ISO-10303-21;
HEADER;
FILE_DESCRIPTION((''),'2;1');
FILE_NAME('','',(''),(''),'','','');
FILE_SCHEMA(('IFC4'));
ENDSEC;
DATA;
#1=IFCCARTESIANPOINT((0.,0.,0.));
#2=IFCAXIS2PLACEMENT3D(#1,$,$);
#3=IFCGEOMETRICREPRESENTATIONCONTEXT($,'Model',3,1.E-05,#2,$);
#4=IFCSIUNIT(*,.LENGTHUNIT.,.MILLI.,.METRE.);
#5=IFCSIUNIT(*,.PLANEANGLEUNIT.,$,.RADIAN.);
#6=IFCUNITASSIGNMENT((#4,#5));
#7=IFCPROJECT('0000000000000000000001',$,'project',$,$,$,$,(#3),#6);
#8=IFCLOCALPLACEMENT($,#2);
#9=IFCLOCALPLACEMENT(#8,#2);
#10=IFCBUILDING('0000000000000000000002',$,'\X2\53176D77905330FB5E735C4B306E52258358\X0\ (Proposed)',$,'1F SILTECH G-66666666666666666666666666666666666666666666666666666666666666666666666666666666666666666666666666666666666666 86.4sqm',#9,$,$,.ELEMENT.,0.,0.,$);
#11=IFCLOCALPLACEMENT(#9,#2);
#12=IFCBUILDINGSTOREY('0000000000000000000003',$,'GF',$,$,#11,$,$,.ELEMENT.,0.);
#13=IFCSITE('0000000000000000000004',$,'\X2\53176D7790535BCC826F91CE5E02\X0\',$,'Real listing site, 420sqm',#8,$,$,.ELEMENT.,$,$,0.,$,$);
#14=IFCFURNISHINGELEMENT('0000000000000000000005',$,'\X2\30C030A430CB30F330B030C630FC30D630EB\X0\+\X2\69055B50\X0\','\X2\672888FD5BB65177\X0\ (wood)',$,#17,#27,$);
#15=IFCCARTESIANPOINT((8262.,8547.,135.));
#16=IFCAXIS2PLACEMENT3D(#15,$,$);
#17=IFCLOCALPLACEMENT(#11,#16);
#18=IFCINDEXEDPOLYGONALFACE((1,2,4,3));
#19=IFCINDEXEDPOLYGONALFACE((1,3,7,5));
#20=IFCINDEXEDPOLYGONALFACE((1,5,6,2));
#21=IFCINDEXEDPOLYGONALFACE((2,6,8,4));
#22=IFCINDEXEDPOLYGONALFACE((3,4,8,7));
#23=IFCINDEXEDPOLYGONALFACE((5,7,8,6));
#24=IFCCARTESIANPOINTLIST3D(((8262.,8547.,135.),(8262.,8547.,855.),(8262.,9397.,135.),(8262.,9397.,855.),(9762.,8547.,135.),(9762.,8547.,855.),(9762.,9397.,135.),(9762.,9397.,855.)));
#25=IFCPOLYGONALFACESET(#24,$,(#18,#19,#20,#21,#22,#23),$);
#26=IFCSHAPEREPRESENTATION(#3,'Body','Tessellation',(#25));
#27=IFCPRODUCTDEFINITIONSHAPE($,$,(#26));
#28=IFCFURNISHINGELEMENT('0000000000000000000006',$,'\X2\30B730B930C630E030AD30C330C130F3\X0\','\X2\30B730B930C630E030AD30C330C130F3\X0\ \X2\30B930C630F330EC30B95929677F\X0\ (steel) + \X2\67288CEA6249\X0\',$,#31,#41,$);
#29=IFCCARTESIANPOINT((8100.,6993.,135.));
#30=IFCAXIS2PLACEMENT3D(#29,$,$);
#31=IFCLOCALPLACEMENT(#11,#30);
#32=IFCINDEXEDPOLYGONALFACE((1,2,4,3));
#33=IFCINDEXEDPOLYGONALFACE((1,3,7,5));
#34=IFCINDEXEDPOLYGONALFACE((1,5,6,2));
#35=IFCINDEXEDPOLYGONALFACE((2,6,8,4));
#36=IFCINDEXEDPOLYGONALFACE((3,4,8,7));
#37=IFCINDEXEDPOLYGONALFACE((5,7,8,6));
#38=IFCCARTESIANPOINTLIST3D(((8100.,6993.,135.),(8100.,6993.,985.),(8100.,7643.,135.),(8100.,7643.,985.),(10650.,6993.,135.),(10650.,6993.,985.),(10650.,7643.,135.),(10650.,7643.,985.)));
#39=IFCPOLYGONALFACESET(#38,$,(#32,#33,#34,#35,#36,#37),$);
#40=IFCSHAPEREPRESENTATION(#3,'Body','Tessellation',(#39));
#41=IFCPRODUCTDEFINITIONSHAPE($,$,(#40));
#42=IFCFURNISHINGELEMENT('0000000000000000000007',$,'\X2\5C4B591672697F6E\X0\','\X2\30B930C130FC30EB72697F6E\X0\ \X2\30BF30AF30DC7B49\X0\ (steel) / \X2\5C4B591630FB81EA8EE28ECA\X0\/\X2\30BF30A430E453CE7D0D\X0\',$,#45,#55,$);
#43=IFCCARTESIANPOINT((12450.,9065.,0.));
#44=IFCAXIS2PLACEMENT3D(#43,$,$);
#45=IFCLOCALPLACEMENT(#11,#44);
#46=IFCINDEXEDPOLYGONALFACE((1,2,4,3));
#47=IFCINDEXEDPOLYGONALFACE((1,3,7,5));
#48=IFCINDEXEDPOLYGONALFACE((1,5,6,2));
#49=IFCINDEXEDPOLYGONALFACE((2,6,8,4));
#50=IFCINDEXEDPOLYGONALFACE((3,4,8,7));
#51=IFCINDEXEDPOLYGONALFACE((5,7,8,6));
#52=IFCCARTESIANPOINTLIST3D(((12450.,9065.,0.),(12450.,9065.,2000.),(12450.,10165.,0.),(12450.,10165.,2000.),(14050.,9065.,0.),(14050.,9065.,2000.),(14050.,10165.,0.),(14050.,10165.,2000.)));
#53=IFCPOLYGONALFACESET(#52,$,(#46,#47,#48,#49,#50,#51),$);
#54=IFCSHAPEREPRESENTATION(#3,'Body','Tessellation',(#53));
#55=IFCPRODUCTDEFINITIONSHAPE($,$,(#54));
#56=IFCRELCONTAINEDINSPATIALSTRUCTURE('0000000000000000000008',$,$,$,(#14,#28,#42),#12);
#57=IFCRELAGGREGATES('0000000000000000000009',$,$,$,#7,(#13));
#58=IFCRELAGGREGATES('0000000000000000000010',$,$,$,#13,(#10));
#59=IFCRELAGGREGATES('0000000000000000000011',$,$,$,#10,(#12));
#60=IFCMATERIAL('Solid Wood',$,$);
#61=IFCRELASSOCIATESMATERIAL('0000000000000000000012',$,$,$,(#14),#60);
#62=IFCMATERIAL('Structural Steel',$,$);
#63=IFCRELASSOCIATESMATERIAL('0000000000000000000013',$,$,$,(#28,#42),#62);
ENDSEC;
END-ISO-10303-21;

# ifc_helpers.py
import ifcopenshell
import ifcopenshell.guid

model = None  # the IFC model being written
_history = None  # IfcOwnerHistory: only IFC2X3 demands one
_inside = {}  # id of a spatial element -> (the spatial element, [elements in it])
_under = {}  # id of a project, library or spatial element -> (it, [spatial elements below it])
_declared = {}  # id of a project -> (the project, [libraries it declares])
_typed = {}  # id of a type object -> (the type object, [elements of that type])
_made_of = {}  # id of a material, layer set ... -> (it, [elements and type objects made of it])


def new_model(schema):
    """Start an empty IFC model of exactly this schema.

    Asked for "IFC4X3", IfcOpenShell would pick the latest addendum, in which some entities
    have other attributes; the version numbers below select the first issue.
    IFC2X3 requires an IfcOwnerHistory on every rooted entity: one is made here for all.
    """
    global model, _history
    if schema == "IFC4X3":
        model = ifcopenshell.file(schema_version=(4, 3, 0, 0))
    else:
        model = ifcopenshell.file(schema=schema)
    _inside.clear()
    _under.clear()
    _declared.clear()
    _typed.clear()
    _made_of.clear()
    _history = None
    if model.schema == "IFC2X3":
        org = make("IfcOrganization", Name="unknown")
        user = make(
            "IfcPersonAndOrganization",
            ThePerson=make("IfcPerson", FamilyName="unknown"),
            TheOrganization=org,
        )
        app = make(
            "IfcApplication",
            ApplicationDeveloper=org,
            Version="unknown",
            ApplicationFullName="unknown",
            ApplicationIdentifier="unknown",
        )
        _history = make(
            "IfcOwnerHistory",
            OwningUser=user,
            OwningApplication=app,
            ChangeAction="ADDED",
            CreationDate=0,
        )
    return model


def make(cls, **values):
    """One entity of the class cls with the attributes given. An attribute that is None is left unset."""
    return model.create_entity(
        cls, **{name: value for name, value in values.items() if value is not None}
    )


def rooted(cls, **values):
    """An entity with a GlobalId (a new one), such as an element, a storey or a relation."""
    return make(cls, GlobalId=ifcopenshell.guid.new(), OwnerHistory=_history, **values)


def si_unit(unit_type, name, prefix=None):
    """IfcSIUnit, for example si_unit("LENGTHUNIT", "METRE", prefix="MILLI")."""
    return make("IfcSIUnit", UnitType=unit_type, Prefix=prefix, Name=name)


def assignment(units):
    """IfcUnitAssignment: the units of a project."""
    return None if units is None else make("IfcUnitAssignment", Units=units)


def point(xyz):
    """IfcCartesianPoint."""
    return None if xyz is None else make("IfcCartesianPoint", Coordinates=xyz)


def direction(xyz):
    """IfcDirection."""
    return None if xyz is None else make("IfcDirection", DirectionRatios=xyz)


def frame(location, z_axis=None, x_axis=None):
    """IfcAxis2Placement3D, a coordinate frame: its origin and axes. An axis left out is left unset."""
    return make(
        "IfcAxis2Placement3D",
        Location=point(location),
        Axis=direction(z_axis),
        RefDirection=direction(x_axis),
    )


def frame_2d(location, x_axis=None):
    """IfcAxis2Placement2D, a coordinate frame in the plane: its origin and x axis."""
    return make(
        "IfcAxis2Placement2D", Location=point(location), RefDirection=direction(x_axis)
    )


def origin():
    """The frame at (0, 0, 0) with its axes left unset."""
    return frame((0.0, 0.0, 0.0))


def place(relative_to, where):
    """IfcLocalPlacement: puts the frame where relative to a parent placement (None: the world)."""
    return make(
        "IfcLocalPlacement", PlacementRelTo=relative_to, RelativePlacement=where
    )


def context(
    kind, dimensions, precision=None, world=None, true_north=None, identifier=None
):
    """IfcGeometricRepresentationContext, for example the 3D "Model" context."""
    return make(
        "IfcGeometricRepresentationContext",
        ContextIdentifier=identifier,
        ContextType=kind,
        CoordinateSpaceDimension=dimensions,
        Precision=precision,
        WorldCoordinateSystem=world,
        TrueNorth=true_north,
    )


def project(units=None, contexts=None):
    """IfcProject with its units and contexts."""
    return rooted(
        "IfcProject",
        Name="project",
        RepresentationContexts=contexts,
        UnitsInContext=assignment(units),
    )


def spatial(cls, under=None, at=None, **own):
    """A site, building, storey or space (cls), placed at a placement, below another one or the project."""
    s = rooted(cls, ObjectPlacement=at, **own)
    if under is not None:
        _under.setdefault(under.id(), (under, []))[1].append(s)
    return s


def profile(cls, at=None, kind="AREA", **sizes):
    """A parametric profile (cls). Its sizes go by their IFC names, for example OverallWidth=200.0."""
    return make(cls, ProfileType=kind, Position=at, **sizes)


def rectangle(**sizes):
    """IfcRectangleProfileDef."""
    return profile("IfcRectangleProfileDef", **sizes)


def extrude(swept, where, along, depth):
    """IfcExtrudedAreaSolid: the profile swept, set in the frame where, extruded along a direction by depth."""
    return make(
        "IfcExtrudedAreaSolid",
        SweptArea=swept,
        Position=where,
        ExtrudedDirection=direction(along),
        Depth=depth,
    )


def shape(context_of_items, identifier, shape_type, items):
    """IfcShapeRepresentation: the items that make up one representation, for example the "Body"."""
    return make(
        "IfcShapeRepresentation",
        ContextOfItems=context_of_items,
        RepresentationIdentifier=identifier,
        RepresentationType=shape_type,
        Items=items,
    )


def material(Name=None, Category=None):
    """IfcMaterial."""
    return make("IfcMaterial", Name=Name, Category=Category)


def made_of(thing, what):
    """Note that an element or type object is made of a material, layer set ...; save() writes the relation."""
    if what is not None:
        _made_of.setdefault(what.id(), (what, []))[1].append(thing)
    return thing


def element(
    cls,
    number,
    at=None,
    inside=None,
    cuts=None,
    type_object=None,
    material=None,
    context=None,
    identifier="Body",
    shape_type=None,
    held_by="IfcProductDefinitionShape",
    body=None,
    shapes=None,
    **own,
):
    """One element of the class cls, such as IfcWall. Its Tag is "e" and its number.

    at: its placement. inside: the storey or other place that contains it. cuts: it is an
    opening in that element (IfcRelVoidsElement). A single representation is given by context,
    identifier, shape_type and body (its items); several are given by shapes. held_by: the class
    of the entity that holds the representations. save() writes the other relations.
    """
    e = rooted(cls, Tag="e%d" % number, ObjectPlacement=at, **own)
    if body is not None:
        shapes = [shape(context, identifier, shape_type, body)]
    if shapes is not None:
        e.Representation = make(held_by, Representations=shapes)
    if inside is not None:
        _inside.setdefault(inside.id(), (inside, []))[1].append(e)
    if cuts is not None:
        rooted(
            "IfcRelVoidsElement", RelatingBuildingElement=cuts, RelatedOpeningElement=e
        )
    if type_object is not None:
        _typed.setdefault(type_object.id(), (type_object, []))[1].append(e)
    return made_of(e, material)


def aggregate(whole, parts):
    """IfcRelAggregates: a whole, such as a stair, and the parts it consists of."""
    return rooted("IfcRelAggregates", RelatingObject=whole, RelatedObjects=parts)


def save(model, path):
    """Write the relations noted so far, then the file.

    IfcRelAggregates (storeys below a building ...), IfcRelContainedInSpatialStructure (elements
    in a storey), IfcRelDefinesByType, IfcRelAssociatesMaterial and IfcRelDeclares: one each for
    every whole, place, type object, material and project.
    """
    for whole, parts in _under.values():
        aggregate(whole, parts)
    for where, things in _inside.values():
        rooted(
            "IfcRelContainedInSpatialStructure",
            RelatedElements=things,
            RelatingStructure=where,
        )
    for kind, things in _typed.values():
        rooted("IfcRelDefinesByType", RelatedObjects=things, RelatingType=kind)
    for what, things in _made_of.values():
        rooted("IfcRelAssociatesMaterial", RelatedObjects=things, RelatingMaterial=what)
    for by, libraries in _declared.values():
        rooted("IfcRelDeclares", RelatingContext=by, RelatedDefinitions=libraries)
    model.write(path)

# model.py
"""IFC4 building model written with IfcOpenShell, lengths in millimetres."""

from ifc_helpers import new_model, si_unit, frame, frame_2d, origin, place, context, project, spatial, rectangle, extrude, material, element, save


model = new_model("IFC4")

# Units and contexts
model_context = context("Model", 3, precision=1e-05, world=origin())
ifc_project = project(units=[si_unit("LENGTHUNIT", "METRE", prefix="MILLI"), si_unit("PLANEANGLEUNIT", "RADIAN")], contexts=[model_context])

# Site, building, storey
site_placement = place(None, origin())
site = spatial("IfcSite", under=ifc_project, at=site_placement, Name="北海道富良野市", ObjectType="Real listing site, 420sqm", CompositionType="ELEMENT", RefElevation=0.0)
building_placement = place(site_placement, origin())
building = spatial("IfcBuilding", under=site, at=building_placement, Name="北海道・平屋の別荘 (Proposed)", ObjectType="1F SILTECH G-66666666666666666666666666666666666666666666666666666666666666666666666666666666666666666666666666666666666666 86.4sqm", CompositionType="ELEMENT", ElevationOfRefHeight=0.0, ElevationOfTerrain=0.0)
storey_placement = place(building_placement, origin())
storey = spatial("IfcBuildingStorey", under=building, at=storey_placement, Name="GF", CompositionType="ELEMENT", Elevation=0.0)

# Shared definitions
ifc_material_1 = material(Name="Solid Wood")

# Shared definitions
ifc_material_2 = material(Name="Structural Steel")

# Furnishing elements
furnishing_1_placement = place(storey_placement, frame((8262.0, 8547.0, 135.0)))
element("IfcFurnishingElement", 1, at=furnishing_1_placement, inside=storey, material=ifc_material_1, Name="ダイニングテーブル+椅子", Description="木製家具 (wood)", context=model_context, shape_type="SweptSolid", body=[
    extrude(rectangle(XDim=1500.0, YDim=850.0, at=frame_2d((750.0, 425.0))), frame((8262.0, 8547.0, 135.0)), (0.0, 0.0, 1.0), 720.0),
])
furnishing_2_placement = place(storey_placement, frame((8100.0, 6993.0, 135.0)))
element("IfcFurnishingElement", 2, at=furnishing_2_placement, inside=storey, material=ifc_material_2, Name="システムキッチン", Description="システムキッチン ステンレス天板 (steel) + 木質扉", context=model_context, shape_type="SweptSolid", body=[
    extrude(rectangle(XDim=2550.0, YDim=650.0, at=frame_2d((1275.0, 325.0))), frame((8100.0, 6993.0, 135.0)), (0.0, 0.0, 1.0), 850.0),
])
furnishing_3_placement = place(storey_placement, frame((12450.0, 9065.0, 0.0)))
element("IfcFurnishingElement", 3, at=furnishing_3_placement, inside=storey, material=ifc_material_2, Name="屋外物置", Description="スチール物置 タクボ等 (steel) / 屋外・自転車/タイヤ収納", context=model_context, shape_type="SweptSolid", body=[
    extrude(rectangle(XDim=1600.0, YDim=1100.0, at=frame_2d((800.0, 550.0))), frame((12450.0, 9065.0, 0.0)), (0.0, 0.0, 1.0), 2000.0),
])

save(model, "model.ifc")
